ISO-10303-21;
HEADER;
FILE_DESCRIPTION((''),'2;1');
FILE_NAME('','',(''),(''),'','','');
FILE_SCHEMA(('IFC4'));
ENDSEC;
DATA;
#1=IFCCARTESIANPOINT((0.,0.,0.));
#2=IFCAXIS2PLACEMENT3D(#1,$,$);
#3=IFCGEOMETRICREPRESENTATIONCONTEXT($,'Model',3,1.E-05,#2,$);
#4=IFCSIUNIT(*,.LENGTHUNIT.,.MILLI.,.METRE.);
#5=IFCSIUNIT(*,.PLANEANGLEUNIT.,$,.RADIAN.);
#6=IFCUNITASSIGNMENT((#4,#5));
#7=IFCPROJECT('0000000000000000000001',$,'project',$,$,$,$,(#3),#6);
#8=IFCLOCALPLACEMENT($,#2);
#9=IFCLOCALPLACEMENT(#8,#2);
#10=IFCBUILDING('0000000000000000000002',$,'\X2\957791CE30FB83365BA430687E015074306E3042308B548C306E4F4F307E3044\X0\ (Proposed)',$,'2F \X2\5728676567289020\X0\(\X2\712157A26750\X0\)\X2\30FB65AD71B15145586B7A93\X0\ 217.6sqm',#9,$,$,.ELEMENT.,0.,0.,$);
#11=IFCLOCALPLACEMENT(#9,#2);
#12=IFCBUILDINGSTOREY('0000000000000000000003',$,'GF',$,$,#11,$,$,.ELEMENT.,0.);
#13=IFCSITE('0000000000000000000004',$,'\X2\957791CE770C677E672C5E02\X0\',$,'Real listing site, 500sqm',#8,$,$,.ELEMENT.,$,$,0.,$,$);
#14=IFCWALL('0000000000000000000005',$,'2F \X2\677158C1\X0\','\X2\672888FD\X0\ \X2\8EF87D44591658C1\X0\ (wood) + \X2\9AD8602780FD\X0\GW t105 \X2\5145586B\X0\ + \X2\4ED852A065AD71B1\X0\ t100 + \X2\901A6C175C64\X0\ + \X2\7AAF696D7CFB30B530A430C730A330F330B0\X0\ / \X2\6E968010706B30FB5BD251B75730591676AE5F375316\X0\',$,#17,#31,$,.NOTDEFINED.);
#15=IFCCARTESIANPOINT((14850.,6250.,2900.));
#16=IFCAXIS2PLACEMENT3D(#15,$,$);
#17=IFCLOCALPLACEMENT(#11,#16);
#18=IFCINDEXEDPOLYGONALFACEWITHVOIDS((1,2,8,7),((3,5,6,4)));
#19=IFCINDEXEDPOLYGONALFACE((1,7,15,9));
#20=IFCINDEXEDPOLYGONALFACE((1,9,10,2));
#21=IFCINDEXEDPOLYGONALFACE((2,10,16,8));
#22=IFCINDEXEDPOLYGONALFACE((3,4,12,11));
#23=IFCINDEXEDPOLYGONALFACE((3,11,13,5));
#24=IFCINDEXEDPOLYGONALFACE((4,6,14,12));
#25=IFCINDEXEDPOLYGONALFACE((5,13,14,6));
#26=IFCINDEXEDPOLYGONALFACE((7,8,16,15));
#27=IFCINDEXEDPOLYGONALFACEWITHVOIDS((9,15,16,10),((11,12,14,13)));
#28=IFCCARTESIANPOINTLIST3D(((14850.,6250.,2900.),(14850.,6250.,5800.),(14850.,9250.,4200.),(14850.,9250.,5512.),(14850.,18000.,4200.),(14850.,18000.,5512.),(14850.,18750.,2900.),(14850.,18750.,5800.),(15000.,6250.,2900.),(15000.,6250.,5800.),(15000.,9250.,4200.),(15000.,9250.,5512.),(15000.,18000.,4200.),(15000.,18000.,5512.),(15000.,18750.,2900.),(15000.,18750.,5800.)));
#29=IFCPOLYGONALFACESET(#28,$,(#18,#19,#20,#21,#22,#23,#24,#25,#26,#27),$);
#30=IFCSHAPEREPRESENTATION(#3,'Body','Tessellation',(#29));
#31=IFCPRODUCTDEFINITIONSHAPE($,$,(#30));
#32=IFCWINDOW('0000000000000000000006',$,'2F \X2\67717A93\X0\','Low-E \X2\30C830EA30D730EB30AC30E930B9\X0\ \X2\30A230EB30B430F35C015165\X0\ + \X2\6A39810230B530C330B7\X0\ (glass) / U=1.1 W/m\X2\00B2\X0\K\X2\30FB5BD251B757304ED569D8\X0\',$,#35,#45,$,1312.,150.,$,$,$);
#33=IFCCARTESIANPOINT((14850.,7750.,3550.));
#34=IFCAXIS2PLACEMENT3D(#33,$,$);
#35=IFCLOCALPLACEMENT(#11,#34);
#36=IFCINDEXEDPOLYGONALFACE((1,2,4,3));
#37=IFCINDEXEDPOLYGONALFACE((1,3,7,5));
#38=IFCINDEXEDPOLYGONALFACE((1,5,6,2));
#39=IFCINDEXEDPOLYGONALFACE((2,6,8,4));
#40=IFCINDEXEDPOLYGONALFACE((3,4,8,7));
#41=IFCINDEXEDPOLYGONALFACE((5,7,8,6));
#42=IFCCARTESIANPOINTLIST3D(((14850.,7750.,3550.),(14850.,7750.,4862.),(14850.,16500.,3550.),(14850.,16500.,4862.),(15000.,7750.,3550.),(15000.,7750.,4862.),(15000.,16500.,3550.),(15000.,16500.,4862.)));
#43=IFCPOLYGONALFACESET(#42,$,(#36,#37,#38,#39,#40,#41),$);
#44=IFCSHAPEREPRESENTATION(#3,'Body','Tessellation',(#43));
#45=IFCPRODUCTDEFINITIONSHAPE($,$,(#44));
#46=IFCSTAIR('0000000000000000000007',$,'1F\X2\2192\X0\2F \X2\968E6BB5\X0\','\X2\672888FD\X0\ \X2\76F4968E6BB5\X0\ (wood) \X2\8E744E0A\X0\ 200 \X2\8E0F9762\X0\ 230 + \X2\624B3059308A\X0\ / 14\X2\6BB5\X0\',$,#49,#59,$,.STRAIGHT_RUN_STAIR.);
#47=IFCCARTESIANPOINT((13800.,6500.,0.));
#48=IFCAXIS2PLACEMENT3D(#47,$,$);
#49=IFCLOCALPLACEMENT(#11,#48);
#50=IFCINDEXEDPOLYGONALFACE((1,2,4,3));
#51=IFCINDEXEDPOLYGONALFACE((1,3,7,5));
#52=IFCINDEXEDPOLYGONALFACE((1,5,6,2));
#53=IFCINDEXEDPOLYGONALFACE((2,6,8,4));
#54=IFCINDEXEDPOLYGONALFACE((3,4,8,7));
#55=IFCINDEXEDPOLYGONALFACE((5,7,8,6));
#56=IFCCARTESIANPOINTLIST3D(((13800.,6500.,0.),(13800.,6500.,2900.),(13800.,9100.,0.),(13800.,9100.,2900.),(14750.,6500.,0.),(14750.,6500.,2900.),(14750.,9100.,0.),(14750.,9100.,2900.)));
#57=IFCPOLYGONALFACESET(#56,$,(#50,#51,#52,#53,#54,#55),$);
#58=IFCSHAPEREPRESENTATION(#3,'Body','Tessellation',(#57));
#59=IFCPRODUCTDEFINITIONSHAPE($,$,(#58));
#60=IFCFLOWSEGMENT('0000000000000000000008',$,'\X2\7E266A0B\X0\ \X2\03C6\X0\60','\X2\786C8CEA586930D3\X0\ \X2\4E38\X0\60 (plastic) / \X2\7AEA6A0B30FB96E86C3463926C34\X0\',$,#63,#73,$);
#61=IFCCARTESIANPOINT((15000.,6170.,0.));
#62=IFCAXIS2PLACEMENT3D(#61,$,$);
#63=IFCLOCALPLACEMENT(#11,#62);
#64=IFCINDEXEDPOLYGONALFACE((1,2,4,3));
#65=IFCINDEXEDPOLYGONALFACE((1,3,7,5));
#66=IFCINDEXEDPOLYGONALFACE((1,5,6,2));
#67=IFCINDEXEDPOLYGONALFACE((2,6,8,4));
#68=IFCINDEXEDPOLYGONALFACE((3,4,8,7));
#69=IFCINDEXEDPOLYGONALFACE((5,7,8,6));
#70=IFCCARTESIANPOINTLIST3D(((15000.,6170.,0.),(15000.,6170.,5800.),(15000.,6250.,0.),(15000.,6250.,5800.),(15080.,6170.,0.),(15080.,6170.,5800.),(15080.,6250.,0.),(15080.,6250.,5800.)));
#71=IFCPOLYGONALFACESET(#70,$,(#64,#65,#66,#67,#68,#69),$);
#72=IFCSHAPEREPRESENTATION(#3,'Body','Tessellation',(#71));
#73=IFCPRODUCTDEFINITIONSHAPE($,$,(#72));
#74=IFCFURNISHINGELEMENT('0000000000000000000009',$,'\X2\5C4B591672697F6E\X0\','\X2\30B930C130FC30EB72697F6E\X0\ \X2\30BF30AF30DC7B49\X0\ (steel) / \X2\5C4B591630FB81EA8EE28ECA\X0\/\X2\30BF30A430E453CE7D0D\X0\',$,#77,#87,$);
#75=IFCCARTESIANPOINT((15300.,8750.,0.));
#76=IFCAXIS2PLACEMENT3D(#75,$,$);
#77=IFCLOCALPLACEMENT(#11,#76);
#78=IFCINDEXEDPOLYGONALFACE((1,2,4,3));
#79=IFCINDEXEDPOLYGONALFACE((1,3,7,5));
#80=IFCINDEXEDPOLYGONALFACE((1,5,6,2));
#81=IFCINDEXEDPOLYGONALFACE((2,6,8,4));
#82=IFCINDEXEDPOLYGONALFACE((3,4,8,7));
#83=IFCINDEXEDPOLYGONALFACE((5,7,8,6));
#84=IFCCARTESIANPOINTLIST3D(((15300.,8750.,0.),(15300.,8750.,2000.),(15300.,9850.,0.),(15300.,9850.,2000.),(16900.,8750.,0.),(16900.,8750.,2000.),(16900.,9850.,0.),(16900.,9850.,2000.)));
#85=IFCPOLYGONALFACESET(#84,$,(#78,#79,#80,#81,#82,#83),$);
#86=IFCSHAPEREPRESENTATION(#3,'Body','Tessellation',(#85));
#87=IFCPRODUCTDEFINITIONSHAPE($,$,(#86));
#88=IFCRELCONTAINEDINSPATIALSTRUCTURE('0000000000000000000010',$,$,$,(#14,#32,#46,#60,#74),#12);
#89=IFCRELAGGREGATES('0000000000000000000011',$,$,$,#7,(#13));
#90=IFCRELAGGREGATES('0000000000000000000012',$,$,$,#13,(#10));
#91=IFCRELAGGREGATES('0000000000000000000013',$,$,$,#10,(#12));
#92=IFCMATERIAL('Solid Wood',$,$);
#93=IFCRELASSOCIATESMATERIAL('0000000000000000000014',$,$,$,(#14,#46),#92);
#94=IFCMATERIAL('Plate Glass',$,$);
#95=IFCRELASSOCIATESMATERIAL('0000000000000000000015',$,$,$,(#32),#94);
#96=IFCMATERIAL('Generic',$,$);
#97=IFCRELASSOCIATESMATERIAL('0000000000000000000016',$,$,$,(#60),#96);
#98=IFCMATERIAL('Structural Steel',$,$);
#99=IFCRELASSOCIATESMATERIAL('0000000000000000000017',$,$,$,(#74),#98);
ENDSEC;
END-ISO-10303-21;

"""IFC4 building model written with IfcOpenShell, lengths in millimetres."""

from ifc_helpers import new_model, si_unit, frame, frame_2d, origin, place, context, project, spatial, rectangle, extrude, material, element, fill, save


model = new_model("IFC4")

# Units and contexts
model_context = context("Model", 3, precision=1e-05, world=origin())
ifc_project = project(units=[si_unit("LENGTHUNIT", "METRE", prefix="MILLI"), si_unit("PLANEANGLEUNIT", "RADIAN")], contexts=[model_context])

# Site, building, storey
site_placement = place(None, origin())
site = spatial("IfcSite", under=ifc_project, at=site_placement, Name="長野県松本市", ObjectType="Real listing site, 500sqm", CompositionType="ELEMENT", RefElevation=0.0)
building_placement = place(site_placement, origin())
building = spatial("IfcBuilding", under=site, at=building_placement, Name="長野・茶室と縁側のある和の住まい (Proposed)", ObjectType="2F 在来木造(無垢材)・断熱充填窓 217.6sqm", CompositionType="ELEMENT", ElevationOfRefHeight=0.0, ElevationOfTerrain=0.0)
storey_placement = place(building_placement, origin())
storey = spatial("IfcBuildingStorey", under=building, at=storey_placement, Name="GF", CompositionType="ELEMENT", Elevation=0.0)

# Shared definitions
ifc_material_1 = material(Name="Solid Wood")

# Wall, opening, window
ifc_material_2 = material(Name="Plate Glass")
wall_1_placement = place(storey_placement, frame((14850.0, 6250.0, 2900.0)))
wall_1 = element("IfcWall", 1, at=wall_1_placement, inside=storey, material=ifc_material_1, Name="2F 東壁", Description="木製 軸組外壁 (wood) + 高性能GW t105 充填 + 付加断熱 t100 + 通気層 + 窯業系サイディング / 準耐火・寒冷地外皮強化", PredefinedType="NOTDEFINED", context=model_context, shape_type="SweptSolid", body=[
    extrude(rectangle(XDim=150.0, YDim=12500.0, at=frame_2d((75.0, 6250.0))), frame((14850.0, 6250.0, 2900.0)), (0.0, 0.0, 1.0), 2900.0),
])
opening_1_placement = place(storey_placement, frame((14850.0, 7750.0, 3550.0)))
opening_1 = element("IfcOpeningElement", 2, at=opening_1_placement, cuts=wall_1, PredefinedType="NOTDEFINED", context=model_context, shape_type="SweptSolid", body=[
    extrude(rectangle(XDim=150.0, YDim=8750.0, at=frame_2d((75.0, 4375.0))), frame((14850.0, 7750.0, 3550.0)), (0.0, 0.0, 1.0), 1312.0),
])
window_1_placement = place(storey_placement, frame((14850.0, 7750.0, 3550.0)))
window_1 = element("IfcWindow", 3, at=window_1_placement, inside=storey, material=ifc_material_2, Name="2F 東窓", Description="Low-E トリプルガラス アルゴン封入 + 樹脂サッシ (glass) / U=1.1 W/m²K・寒冷地仕様", OverallHeight=1312.0, OverallWidth=150.0, context=model_context, shape_type="SweptSolid", body=[
    extrude(rectangle(XDim=150.0, YDim=8750.0, at=frame_2d((75.0, 4375.0))), frame((14850.0, 7750.0, 3550.0)), (0.0, 0.0, 1.0), 1312.0),
])
fill(opening_1, window_1)

# Stair
stair_placement = place(storey_placement, frame((13800.0, 6500.0, 0.0)))
element("IfcStair", 4, at=stair_placement, inside=storey, material=ifc_material_1, Name="1F→2F 階段", Description="木製 直階段 (wood) 蹴上 200 踏面 230 + 手すり / 14段", PredefinedType="STRAIGHT_RUN_STAIR", context=model_context, shape_type="SweptSolid", body=[
    extrude(rectangle(XDim=950.0, YDim=2600.0, at=frame_2d((475.0, 1300.0))), frame((13800.0, 6500.0, 0.0)), (0.0, 0.0, 1.0), 2900.0),
])

# Flow segment
ifc_material_3 = material(Name="Generic")
flow_segment_placement = place(storey_placement, frame((15000.0, 6170.0, 0.0)))
element("IfcFlowSegment", 5, at=flow_segment_placement, inside=storey, material=ifc_material_3, Name="縦樋 φ60", Description="硬質塩ビ 丸60 (plastic) / 竪樋・雨水排水", context=model_context, shape_type="SweptSolid", body=[
    extrude(rectangle(XDim=80.0, YDim=80.0, at=frame_2d((40.0, 40.0))), frame((15000.0, 6170.0, 0.0)), (0.0, 0.0, 1.0), 5800.0),
])

# Furnishing element
ifc_material_4 = material(Name="Structural Steel")
furnishing_placement = place(storey_placement, frame((15300.0, 8750.0, 0.0)))
element("IfcFurnishingElement", 6, at=furnishing_placement, inside=storey, material=ifc_material_4, Name="屋外物置", Description="スチール物置 タクボ等 (steel) / 屋外・自転車/タイヤ収納", context=model_context, shape_type="SweptSolid", body=[
    extrude(rectangle(XDim=1600.0, YDim=1100.0, at=frame_2d((800.0, 550.0))), frame((15300.0, 8750.0, 0.0)), (0.0, 0.0, 1.0), 2000.0),
])

save(model, "model.ifc")
